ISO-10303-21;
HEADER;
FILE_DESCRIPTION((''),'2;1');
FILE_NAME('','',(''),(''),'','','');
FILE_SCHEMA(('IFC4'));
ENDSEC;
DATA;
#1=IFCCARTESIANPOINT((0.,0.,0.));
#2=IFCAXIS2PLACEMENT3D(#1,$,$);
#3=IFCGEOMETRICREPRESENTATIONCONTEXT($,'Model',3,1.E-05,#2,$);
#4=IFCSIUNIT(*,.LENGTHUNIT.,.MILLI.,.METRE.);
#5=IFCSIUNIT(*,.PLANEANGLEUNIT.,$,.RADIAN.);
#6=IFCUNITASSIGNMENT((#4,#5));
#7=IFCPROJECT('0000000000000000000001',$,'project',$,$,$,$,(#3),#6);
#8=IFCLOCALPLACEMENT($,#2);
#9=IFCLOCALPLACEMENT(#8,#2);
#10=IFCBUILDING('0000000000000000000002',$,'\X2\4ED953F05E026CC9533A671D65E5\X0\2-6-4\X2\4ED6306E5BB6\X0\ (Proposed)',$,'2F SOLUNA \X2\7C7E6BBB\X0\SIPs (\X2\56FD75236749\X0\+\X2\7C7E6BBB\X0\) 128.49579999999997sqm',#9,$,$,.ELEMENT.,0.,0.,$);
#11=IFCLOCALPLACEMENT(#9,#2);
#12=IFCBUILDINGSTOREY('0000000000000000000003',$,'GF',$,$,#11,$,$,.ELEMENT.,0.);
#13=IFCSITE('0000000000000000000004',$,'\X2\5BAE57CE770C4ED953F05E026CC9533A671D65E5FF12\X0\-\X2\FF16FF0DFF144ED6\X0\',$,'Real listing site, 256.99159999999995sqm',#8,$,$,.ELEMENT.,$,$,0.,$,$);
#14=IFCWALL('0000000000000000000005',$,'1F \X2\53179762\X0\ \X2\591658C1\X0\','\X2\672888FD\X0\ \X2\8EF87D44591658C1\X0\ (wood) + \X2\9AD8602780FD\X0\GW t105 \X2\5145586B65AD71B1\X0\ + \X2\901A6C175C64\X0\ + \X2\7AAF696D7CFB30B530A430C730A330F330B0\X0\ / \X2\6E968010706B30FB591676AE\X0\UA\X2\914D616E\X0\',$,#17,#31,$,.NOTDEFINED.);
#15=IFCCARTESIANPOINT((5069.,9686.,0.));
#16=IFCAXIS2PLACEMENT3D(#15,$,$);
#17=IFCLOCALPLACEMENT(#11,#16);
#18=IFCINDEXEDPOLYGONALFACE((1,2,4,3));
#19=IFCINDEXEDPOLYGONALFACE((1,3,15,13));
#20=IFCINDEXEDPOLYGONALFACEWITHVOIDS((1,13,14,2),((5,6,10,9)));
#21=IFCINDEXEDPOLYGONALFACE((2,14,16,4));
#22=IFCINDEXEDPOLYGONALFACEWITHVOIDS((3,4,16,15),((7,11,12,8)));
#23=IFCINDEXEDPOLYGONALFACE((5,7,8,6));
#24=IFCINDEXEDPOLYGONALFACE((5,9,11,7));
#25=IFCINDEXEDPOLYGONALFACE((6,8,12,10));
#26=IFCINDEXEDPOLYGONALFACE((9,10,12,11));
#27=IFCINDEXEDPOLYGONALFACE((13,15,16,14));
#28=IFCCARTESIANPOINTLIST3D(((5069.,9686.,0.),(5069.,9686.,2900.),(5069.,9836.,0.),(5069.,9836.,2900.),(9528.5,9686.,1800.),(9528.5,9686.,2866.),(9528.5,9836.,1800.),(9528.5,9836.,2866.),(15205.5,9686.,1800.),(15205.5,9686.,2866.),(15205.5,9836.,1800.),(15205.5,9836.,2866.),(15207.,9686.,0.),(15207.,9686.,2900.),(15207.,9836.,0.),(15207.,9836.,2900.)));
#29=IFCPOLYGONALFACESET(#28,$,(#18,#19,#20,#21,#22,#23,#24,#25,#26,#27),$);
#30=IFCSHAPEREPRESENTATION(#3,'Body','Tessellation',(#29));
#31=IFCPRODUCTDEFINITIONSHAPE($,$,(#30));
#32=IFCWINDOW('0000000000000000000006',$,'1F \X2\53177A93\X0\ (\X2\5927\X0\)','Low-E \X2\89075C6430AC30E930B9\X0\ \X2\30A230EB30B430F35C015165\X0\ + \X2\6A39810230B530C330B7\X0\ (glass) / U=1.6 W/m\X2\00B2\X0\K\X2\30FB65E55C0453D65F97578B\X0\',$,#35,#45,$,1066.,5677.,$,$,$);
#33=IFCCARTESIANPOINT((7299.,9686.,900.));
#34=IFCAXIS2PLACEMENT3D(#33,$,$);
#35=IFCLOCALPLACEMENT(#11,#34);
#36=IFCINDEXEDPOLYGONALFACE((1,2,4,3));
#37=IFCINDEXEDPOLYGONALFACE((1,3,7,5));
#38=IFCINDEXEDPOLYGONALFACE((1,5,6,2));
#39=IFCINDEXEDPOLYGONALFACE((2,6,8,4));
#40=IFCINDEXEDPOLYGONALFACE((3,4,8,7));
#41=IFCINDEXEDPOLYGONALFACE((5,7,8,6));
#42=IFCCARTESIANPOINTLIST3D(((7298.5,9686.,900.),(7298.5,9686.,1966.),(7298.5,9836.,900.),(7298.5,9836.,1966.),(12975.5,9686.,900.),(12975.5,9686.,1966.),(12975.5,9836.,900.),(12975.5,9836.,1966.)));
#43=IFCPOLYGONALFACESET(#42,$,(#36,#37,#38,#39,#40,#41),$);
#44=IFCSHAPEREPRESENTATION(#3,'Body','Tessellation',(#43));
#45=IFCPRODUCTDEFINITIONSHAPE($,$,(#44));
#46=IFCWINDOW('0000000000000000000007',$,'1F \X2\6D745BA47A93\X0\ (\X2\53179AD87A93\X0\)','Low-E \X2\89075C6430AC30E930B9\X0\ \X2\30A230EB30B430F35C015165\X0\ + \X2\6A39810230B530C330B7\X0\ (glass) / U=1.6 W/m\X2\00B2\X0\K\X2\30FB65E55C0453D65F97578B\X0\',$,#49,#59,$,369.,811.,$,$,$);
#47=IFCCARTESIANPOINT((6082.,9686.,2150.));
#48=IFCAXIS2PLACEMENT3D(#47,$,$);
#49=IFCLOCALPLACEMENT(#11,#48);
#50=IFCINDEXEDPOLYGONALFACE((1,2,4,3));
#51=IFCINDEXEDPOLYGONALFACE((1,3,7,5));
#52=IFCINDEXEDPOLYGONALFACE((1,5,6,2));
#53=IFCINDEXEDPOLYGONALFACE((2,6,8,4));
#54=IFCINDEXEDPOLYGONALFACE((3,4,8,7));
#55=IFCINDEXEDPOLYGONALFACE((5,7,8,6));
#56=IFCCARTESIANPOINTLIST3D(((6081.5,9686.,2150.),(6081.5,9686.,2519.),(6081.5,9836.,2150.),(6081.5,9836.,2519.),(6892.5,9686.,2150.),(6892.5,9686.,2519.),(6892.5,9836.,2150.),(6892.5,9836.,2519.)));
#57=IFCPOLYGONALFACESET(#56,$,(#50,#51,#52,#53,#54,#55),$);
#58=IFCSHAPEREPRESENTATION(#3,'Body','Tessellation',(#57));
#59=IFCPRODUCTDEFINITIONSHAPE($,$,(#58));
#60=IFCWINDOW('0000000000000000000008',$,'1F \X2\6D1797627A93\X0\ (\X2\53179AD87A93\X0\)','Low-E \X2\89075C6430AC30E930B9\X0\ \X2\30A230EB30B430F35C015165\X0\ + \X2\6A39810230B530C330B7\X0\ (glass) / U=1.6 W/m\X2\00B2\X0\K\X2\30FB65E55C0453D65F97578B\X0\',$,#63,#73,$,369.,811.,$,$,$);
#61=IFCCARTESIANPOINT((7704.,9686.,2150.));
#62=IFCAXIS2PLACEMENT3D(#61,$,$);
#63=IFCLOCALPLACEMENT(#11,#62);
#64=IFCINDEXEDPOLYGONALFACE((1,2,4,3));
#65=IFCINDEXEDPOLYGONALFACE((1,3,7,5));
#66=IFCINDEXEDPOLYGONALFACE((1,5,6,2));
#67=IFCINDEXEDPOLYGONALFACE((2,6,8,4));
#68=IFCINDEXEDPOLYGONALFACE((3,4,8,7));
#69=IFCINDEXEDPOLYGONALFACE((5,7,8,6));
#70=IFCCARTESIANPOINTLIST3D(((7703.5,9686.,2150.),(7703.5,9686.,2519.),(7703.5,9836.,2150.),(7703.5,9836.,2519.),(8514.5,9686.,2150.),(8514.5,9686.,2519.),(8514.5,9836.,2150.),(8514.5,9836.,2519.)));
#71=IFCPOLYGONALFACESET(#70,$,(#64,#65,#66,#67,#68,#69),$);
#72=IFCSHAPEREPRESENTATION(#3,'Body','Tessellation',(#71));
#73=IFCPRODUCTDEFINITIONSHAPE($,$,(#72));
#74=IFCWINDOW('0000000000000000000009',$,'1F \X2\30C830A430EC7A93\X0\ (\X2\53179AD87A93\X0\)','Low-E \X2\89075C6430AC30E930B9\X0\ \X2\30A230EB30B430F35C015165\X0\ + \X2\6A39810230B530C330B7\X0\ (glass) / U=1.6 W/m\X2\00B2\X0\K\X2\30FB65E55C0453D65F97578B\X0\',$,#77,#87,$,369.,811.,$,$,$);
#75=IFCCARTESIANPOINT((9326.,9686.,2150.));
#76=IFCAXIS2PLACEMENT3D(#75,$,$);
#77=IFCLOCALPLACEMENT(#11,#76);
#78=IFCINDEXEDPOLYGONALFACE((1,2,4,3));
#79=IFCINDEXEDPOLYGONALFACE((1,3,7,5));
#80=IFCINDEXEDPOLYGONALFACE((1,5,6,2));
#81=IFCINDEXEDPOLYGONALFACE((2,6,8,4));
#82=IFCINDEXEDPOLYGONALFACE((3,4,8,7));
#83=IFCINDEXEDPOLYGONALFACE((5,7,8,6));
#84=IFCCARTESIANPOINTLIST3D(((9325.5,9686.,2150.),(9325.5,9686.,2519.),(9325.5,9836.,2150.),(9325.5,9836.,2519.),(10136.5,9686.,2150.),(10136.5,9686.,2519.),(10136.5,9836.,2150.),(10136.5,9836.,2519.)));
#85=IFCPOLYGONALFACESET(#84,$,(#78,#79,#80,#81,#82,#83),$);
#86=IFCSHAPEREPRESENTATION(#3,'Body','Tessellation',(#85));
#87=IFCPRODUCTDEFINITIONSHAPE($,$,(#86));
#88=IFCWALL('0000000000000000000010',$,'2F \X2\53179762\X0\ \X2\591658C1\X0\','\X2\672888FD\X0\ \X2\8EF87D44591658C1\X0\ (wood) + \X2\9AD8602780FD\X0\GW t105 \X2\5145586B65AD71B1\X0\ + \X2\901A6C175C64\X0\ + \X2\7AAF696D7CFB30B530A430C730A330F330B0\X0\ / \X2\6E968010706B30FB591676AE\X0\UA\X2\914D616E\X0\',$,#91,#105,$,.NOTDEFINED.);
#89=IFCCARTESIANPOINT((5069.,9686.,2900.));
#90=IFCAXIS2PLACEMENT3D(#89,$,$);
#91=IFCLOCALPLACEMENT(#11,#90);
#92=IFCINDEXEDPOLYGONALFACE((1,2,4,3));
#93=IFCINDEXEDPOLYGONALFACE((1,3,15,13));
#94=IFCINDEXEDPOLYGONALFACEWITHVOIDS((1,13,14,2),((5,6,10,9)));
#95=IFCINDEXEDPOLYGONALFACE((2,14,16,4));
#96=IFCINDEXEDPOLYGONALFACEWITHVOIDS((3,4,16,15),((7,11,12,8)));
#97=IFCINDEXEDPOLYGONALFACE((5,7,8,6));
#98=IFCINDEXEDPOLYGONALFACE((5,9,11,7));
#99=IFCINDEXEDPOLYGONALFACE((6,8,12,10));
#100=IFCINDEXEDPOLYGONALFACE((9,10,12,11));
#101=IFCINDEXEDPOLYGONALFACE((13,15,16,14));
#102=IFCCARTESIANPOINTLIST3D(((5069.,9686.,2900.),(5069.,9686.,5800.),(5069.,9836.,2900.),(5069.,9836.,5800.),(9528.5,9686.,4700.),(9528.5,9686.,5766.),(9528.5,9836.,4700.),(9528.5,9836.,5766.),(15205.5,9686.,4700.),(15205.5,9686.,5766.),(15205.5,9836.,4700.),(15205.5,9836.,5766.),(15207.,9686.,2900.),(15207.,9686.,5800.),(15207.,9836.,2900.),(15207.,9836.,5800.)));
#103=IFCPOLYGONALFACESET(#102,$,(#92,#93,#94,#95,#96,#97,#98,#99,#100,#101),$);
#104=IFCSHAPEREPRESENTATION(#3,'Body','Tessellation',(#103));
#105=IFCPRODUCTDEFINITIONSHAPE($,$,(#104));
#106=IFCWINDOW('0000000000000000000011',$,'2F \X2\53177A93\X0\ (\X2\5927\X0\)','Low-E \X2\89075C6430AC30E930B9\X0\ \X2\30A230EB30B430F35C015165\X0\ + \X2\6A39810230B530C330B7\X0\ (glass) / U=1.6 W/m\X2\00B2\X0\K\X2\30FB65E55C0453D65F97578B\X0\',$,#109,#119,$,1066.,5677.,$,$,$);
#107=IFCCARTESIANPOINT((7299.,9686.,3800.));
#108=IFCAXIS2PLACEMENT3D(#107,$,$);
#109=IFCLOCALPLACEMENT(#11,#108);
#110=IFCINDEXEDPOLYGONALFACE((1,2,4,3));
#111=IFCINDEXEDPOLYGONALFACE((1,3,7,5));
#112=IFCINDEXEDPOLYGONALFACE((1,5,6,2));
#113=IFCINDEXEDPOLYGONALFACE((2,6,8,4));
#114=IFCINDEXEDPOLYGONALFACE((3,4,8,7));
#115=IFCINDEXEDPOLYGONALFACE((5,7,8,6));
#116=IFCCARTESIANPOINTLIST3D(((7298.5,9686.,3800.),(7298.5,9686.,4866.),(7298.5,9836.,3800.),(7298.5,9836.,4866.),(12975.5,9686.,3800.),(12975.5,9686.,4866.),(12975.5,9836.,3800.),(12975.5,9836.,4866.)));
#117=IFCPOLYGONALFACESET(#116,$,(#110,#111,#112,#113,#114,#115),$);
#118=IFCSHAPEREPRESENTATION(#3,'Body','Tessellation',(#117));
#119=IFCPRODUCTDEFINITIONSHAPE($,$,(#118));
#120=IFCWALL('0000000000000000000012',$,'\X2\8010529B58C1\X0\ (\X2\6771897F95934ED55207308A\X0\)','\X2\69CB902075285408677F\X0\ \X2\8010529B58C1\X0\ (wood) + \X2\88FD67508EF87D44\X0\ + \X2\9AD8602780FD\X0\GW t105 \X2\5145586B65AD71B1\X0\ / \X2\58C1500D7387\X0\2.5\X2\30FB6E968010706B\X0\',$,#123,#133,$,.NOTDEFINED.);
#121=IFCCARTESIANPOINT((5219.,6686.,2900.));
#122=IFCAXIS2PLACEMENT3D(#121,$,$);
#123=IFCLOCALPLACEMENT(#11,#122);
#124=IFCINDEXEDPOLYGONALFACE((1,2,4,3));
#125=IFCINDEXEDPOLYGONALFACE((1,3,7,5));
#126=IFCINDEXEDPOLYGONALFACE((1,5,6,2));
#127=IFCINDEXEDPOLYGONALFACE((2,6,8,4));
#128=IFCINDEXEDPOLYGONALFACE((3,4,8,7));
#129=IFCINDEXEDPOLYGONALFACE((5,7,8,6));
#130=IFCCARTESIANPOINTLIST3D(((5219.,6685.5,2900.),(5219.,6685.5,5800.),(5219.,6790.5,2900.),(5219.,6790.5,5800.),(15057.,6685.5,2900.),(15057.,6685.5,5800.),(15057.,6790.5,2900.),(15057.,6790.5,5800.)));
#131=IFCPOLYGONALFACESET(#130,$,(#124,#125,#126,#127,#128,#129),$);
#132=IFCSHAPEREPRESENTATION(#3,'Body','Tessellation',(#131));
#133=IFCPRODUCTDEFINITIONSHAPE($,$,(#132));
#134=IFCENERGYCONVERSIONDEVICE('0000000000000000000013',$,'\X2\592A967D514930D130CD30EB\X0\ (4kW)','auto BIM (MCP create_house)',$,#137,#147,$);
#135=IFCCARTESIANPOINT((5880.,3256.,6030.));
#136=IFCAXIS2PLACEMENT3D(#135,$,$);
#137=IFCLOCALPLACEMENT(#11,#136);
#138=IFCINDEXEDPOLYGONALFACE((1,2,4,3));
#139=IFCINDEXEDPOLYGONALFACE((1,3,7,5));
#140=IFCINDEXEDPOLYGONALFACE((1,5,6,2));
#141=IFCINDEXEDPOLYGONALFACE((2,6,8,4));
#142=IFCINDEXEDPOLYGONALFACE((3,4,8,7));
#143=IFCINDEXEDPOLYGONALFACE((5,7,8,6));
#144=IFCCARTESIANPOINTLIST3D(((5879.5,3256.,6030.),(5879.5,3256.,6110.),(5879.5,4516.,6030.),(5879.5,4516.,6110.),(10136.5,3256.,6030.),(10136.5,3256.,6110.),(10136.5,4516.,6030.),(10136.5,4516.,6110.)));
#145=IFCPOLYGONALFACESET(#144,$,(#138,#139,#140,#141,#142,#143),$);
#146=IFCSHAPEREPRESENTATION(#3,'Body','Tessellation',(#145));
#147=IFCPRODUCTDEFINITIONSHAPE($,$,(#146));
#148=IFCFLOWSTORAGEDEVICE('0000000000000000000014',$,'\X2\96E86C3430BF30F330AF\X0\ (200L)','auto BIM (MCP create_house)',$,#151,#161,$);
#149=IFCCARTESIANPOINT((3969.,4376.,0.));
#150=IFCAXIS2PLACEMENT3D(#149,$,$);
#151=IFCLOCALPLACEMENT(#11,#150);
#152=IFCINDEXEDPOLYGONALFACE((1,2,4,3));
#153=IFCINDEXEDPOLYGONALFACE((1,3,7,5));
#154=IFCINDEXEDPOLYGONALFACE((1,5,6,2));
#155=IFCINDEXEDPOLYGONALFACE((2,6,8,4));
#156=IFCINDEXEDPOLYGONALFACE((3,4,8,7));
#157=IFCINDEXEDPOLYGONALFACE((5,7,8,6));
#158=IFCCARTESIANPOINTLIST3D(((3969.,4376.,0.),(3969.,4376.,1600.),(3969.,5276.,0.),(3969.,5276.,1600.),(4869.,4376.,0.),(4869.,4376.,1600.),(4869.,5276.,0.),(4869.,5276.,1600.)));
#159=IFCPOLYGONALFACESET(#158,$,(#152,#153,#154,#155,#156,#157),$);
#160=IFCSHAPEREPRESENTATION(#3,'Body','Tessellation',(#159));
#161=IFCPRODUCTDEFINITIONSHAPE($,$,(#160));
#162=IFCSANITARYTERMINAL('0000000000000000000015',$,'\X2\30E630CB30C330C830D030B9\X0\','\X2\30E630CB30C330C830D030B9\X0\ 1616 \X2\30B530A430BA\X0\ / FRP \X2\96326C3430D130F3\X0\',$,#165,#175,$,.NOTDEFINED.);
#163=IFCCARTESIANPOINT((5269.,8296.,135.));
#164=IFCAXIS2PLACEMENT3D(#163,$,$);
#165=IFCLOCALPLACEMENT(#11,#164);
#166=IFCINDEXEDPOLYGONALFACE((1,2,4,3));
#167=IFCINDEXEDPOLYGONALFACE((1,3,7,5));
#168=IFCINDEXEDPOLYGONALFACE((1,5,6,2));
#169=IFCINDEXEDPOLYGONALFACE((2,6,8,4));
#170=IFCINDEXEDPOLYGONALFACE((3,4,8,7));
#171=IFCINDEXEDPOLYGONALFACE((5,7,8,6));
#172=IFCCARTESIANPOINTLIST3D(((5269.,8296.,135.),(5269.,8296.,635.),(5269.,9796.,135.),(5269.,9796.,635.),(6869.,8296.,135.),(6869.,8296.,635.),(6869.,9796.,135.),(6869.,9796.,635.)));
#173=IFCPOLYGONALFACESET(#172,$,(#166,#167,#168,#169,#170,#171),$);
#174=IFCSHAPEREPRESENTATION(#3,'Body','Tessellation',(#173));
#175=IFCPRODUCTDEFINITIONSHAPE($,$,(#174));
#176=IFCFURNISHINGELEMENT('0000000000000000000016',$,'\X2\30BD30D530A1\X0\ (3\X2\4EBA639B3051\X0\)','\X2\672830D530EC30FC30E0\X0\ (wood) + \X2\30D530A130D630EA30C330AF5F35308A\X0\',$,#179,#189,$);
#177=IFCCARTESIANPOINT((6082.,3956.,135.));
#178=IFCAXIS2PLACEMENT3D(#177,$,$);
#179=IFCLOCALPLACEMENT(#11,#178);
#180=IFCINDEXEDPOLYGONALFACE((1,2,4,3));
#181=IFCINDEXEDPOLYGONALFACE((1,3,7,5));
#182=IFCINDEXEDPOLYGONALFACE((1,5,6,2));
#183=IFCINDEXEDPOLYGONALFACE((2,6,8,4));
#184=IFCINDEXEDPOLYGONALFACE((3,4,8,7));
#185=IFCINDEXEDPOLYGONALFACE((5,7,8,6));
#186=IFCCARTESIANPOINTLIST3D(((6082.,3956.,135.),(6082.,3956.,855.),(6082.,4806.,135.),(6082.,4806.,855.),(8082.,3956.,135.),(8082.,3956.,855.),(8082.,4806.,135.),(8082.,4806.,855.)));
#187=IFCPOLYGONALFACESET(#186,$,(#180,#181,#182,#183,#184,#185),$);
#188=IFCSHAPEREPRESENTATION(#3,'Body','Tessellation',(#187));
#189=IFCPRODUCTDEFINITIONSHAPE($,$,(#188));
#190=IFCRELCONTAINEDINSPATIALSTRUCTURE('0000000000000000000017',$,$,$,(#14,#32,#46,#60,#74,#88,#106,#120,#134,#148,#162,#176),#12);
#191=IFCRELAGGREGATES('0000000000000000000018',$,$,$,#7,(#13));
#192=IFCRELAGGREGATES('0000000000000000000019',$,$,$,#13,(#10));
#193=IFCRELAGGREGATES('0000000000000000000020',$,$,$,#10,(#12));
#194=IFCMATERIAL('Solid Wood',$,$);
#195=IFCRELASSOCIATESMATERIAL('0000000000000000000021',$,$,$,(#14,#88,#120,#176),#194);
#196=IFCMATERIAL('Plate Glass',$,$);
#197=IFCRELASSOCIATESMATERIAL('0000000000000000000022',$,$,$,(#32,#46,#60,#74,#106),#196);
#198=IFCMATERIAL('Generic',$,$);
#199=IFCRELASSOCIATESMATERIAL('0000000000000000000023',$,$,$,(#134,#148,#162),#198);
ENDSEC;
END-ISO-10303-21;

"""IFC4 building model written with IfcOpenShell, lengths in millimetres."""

from ifc_helpers import new_model, si_unit, frame, frame_2d, origin, place, context, project, spatial, rectangle, extrude, material, element, fill, save


model = new_model("IFC4")

# Units and contexts
model_context = context("Model", 3, precision=1e-05, world=origin())
ifc_project = project(units=[si_unit("LENGTHUNIT", "METRE", prefix="MILLI"), si_unit("PLANEANGLEUNIT", "RADIAN")], contexts=[model_context])

# Site, building, storey
site_placement = place(None, origin())
site = spatial("IfcSite", under=ifc_project, at=site_placement, Name="宮城県仙台市泉区朝日２-６－４他", ObjectType="Real listing site, 256.99159999999995sqm", CompositionType="ELEMENT", RefElevation=0.0)
building_placement = place(site_placement, origin())
building = spatial("IfcBuilding", under=site, at=building_placement, Name="仙台市泉区朝日2-6-4他の家 (Proposed)", ObjectType="2F SOLUNA 籾殻SIPs (国産杉+籾殻) 128.49579999999997sqm", CompositionType="ELEMENT", ElevationOfRefHeight=0.0, ElevationOfTerrain=0.0)
storey_placement = place(building_placement, origin())
storey = spatial("IfcBuildingStorey", under=building, at=storey_placement, Name="GF", CompositionType="ELEMENT", Elevation=0.0)

# Wall, openings, windows
ifc_material_1 = material(Name="Solid Wood")
wall_1_placement = place(storey_placement, frame((5069.0, 9686.0, 0.0)))
wall_1 = element("IfcWall", 1, at=wall_1_placement, inside=storey, material=ifc_material_1, Name="1F 北面 外壁", Description="木製 軸組外壁 (wood) + 高性能GW t105 充填断熱 + 通気層 + 窯業系サイディング / 準耐火・外皮UA配慮", PredefinedType="NOTDEFINED", context=model_context, shape_type="SweptSolid", body=[
    extrude(rectangle(XDim=10138.0, YDim=150.0, at=frame_2d((5069.0, 75.0))), frame((5069.0, 9686.0, 0.0)), (0.0, 0.0, 1.0), 2900.0),
])
opening_1_placement = place(storey_placement, frame((7299.0, 9686.0, 900.0)))
opening_1 = element("IfcOpeningElement", 2, at=opening_1_placement, cuts=wall_1, PredefinedType="NOTDEFINED", context=model_context, shape_type="SweptSolid", body=[
    extrude(rectangle(XDim=5677.0, YDim=150.0, at=frame_2d((2838.0, 75.0))), frame((7299.0, 9686.0, 900.0)), (0.0, 0.0, 1.0), 1066.0),
])
opening_2_placement = place(storey_placement, frame((6082.0, 9686.0, 2150.0)))
opening_2 = element("IfcOpeningElement", 3, at=opening_2_placement, cuts=wall_1, PredefinedType="NOTDEFINED", context=model_context, shape_type="SweptSolid", body=[
    extrude(rectangle(XDim=811.0, YDim=150.0, at=frame_2d((405.0, 75.0))), frame((6082.0, 9686.0, 2150.0)), (0.0, 0.0, 1.0), 369.0),
])
opening_3_placement = place(storey_placement, frame((7704.0, 9686.0, 2150.0)))
opening_3 = element("IfcOpeningElement", 4, at=opening_3_placement, cuts=wall_1, PredefinedType="NOTDEFINED", context=model_context, shape_type="SweptSolid", body=[
    extrude(rectangle(XDim=811.0, YDim=150.0, at=frame_2d((405.0, 75.0))), frame((7704.0, 9686.0, 2150.0)), (0.0, 0.0, 1.0), 369.0),
])
opening_4_placement = place(storey_placement, frame((9326.0, 9686.0, 2150.0)))
opening_4 = element("IfcOpeningElement", 5, at=opening_4_placement, cuts=wall_1, PredefinedType="NOTDEFINED", context=model_context, shape_type="SweptSolid", body=[
    extrude(rectangle(XDim=811.0, YDim=150.0, at=frame_2d((405.0, 75.0))), frame((9326.0, 9686.0, 2150.0)), (0.0, 0.0, 1.0), 369.0),
])
ifc_material_2 = material(Name="Plate Glass")
window_1_placement = place(storey_placement, frame((7299.0, 9686.0, 900.0)))
window_1 = element("IfcWindow", 6, at=window_1_placement, inside=storey, material=ifc_material_2, Name="1F 北窓 (大)", Description="Low-E 複層ガラス アルゴン封入 + 樹脂サッシ (glass) / U=1.6 W/m²K・日射取得型", OverallHeight=1066.0, OverallWidth=5677.0, context=model_context, shape_type="SweptSolid", body=[
    extrude(rectangle(XDim=5677.0, YDim=150.0, at=frame_2d((2838.0, 75.0))), frame((7299.0, 9686.0, 900.0)), (0.0, 0.0, 1.0), 1066.0),
])
fill(opening_1, window_1)
window_2_placement = place(storey_placement, frame((6082.0, 9686.0, 2150.0)))
window_2 = element("IfcWindow", 7, at=window_2_placement, inside=storey, material=ifc_material_2, Name="1F 浴室窓 (北高窓)", Description="Low-E 複層ガラス アルゴン封入 + 樹脂サッシ (glass) / U=1.6 W/m²K・日射取得型", OverallHeight=369.0, OverallWidth=811.0, context=model_context, shape_type="SweptSolid", body=[
    extrude(rectangle(XDim=811.0, YDim=150.0, at=frame_2d((405.0, 75.0))), frame((6082.0, 9686.0, 2150.0)), (0.0, 0.0, 1.0), 369.0),
])
fill(opening_2, window_2)
window_3_placement = place(storey_placement, frame((7704.0, 9686.0, 2150.0)))
window_3 = element("IfcWindow", 8, at=window_3_placement, inside=storey, material=ifc_material_2, Name="1F 洗面窓 (北高窓)", Description="Low-E 複層ガラス アルゴン封入 + 樹脂サッシ (glass) / U=1.6 W/m²K・日射取得型", OverallHeight=369.0, OverallWidth=811.0, context=model_context, shape_type="SweptSolid", body=[
    extrude(rectangle(XDim=811.0, YDim=150.0, at=frame_2d((405.0, 75.0))), frame((7704.0, 9686.0, 2150.0)), (0.0, 0.0, 1.0), 369.0),
])
fill(opening_3, window_3)
window_4_placement = place(storey_placement, frame((9326.0, 9686.0, 2150.0)))
window_4 = element("IfcWindow", 9, at=window_4_placement, inside=storey, material=ifc_material_2, Name="1F トイレ窓 (北高窓)", Description="Low-E 複層ガラス アルゴン封入 + 樹脂サッシ (glass) / U=1.6 W/m²K・日射取得型", OverallHeight=369.0, OverallWidth=811.0, context=model_context, shape_type="SweptSolid", body=[
    extrude(rectangle(XDim=811.0, YDim=150.0, at=frame_2d((405.0, 75.0))), frame((9326.0, 9686.0, 2150.0)), (0.0, 0.0, 1.0), 369.0),
])
fill(opening_4, window_4)

# Wall, opening, window
wall_2_placement = place(storey_placement, frame((5069.0, 9686.0, 2900.0)))
wall_2 = element("IfcWall", 10, at=wall_2_placement, inside=storey, material=ifc_material_1, Name="2F 北面 外壁", Description="木製 軸組外壁 (wood) + 高性能GW t105 充填断熱 + 通気層 + 窯業系サイディング / 準耐火・外皮UA配慮", PredefinedType="NOTDEFINED", context=model_context, shape_type="SweptSolid", body=[
    extrude(rectangle(XDim=10138.0, YDim=150.0, at=frame_2d((5069.0, 75.0))), frame((5069.0, 9686.0, 2900.0)), (0.0, 0.0, 1.0), 2900.0),
])
opening_5_placement = place(storey_placement, frame((7299.0, 9686.0, 3800.0)))
opening_5 = element("IfcOpeningElement", 11, at=opening_5_placement, cuts=wall_2, PredefinedType="NOTDEFINED", context=model_context, shape_type="SweptSolid", body=[
    extrude(rectangle(XDim=5677.0, YDim=150.0, at=frame_2d((2838.0, 75.0))), frame((7299.0, 9686.0, 3800.0)), (0.0, 0.0, 1.0), 1066.0),
])
window_5_placement = place(storey_placement, frame((7299.0, 9686.0, 3800.0)))
window_5 = element("IfcWindow", 12, at=window_5_placement, inside=storey, material=ifc_material_2, Name="2F 北窓 (大)", Description="Low-E 複層ガラス アルゴン封入 + 樹脂サッシ (glass) / U=1.6 W/m²K・日射取得型", OverallHeight=1066.0, OverallWidth=5677.0, context=model_context, shape_type="SweptSolid", body=[
    extrude(rectangle(XDim=5677.0, YDim=150.0, at=frame_2d((2838.0, 75.0))), frame((7299.0, 9686.0, 3800.0)), (0.0, 0.0, 1.0), 1066.0),
])
fill(opening_5, window_5)

# Wall
wall_3_placement = place(storey_placement, frame((5219.0, 6686.0, 2900.0)))
element("IfcWall", 13, at=wall_3_placement, inside=storey, material=ifc_material_1, Name="耐力壁 (東西間仕切り)", Description="構造用合板 耐力壁 (wood) + 製材軸組 + 高性能GW t105 充填断熱 / 壁倍率2.5・準耐火", PredefinedType="NOTDEFINED", context=model_context, shape_type="SweptSolid", body=[
    extrude(rectangle(XDim=9838.0, YDim=105.0, at=frame_2d((4919.0, 52.0))), frame((5219.0, 6686.0, 2900.0)), (0.0, 0.0, 1.0), 2900.0),
])

# Energy conversion device
ifc_material_3 = material(Name="Generic")
energy_conversion_device_placement = place(storey_placement, frame((5880.0, 3256.0, 6030.0)))
element("IfcEnergyConversionDevice", 14, at=energy_conversion_device_placement, inside=storey, material=ifc_material_3, Name="太陽光パネル (4kW)", Description="auto BIM (MCP create_house)", context=model_context, shape_type="SweptSolid", body=[
    extrude(rectangle(XDim=4257.0, YDim=1260.0, at=frame_2d((2128.0, 630.0))), frame((5880.0, 3256.0, 6030.0)), (0.0, 0.0, 1.0), 80.0),
])

# Flow storage device
flow_storage_device_placement = place(storey_placement, frame((3969.0, 4376.0, 0.0)))
element("IfcFlowStorageDevice", 15, at=flow_storage_device_placement, inside=storey, material=ifc_material_3, Name="雨水タンク (200L)", Description="auto BIM (MCP create_house)", context=model_context, shape_type="SweptSolid", body=[
    extrude(rectangle(XDim=900.0, YDim=900.0, at=frame_2d((450.0, 450.0))), frame((3969.0, 4376.0, 0.0)), (0.0, 0.0, 1.0), 1600.0),
])

# Sanitary terminal
sanitary_terminal_placement = place(storey_placement, frame((5269.0, 8296.0, 135.0)))
element("IfcSanitaryTerminal", 16, at=sanitary_terminal_placement, inside=storey, material=ifc_material_3, Name="ユニットバス", Description="ユニットバス 1616 サイズ / FRP 防水パン", PredefinedType="NOTDEFINED", context=model_context, shape_type="SweptSolid", body=[
    extrude(rectangle(XDim=1600.0, YDim=1500.0, at=frame_2d((800.0, 750.0))), frame((5269.0, 8296.0, 135.0)), (0.0, 0.0, 1.0), 500.0),
])

# Furnishing element
furnishing_1_placement = place(storey_placement, frame((6082.0, 3956.0, 135.0)))
element("IfcFurnishingElement", 17, at=furnishing_1_placement, inside=storey, material=ifc_material_1, Name="ソファ (3人掛け)", Description="木フレーム (wood) + ファブリック張り", context=model_context, shape_type="SweptSolid", body=[
    extrude(rectangle(XDim=2000.0, YDim=850.0, at=frame_2d((1000.0, 425.0))), frame((6082.0, 3956.0, 135.0)), (0.0, 0.0, 1.0), 720.0),
])

save(model, "model.ifc")
